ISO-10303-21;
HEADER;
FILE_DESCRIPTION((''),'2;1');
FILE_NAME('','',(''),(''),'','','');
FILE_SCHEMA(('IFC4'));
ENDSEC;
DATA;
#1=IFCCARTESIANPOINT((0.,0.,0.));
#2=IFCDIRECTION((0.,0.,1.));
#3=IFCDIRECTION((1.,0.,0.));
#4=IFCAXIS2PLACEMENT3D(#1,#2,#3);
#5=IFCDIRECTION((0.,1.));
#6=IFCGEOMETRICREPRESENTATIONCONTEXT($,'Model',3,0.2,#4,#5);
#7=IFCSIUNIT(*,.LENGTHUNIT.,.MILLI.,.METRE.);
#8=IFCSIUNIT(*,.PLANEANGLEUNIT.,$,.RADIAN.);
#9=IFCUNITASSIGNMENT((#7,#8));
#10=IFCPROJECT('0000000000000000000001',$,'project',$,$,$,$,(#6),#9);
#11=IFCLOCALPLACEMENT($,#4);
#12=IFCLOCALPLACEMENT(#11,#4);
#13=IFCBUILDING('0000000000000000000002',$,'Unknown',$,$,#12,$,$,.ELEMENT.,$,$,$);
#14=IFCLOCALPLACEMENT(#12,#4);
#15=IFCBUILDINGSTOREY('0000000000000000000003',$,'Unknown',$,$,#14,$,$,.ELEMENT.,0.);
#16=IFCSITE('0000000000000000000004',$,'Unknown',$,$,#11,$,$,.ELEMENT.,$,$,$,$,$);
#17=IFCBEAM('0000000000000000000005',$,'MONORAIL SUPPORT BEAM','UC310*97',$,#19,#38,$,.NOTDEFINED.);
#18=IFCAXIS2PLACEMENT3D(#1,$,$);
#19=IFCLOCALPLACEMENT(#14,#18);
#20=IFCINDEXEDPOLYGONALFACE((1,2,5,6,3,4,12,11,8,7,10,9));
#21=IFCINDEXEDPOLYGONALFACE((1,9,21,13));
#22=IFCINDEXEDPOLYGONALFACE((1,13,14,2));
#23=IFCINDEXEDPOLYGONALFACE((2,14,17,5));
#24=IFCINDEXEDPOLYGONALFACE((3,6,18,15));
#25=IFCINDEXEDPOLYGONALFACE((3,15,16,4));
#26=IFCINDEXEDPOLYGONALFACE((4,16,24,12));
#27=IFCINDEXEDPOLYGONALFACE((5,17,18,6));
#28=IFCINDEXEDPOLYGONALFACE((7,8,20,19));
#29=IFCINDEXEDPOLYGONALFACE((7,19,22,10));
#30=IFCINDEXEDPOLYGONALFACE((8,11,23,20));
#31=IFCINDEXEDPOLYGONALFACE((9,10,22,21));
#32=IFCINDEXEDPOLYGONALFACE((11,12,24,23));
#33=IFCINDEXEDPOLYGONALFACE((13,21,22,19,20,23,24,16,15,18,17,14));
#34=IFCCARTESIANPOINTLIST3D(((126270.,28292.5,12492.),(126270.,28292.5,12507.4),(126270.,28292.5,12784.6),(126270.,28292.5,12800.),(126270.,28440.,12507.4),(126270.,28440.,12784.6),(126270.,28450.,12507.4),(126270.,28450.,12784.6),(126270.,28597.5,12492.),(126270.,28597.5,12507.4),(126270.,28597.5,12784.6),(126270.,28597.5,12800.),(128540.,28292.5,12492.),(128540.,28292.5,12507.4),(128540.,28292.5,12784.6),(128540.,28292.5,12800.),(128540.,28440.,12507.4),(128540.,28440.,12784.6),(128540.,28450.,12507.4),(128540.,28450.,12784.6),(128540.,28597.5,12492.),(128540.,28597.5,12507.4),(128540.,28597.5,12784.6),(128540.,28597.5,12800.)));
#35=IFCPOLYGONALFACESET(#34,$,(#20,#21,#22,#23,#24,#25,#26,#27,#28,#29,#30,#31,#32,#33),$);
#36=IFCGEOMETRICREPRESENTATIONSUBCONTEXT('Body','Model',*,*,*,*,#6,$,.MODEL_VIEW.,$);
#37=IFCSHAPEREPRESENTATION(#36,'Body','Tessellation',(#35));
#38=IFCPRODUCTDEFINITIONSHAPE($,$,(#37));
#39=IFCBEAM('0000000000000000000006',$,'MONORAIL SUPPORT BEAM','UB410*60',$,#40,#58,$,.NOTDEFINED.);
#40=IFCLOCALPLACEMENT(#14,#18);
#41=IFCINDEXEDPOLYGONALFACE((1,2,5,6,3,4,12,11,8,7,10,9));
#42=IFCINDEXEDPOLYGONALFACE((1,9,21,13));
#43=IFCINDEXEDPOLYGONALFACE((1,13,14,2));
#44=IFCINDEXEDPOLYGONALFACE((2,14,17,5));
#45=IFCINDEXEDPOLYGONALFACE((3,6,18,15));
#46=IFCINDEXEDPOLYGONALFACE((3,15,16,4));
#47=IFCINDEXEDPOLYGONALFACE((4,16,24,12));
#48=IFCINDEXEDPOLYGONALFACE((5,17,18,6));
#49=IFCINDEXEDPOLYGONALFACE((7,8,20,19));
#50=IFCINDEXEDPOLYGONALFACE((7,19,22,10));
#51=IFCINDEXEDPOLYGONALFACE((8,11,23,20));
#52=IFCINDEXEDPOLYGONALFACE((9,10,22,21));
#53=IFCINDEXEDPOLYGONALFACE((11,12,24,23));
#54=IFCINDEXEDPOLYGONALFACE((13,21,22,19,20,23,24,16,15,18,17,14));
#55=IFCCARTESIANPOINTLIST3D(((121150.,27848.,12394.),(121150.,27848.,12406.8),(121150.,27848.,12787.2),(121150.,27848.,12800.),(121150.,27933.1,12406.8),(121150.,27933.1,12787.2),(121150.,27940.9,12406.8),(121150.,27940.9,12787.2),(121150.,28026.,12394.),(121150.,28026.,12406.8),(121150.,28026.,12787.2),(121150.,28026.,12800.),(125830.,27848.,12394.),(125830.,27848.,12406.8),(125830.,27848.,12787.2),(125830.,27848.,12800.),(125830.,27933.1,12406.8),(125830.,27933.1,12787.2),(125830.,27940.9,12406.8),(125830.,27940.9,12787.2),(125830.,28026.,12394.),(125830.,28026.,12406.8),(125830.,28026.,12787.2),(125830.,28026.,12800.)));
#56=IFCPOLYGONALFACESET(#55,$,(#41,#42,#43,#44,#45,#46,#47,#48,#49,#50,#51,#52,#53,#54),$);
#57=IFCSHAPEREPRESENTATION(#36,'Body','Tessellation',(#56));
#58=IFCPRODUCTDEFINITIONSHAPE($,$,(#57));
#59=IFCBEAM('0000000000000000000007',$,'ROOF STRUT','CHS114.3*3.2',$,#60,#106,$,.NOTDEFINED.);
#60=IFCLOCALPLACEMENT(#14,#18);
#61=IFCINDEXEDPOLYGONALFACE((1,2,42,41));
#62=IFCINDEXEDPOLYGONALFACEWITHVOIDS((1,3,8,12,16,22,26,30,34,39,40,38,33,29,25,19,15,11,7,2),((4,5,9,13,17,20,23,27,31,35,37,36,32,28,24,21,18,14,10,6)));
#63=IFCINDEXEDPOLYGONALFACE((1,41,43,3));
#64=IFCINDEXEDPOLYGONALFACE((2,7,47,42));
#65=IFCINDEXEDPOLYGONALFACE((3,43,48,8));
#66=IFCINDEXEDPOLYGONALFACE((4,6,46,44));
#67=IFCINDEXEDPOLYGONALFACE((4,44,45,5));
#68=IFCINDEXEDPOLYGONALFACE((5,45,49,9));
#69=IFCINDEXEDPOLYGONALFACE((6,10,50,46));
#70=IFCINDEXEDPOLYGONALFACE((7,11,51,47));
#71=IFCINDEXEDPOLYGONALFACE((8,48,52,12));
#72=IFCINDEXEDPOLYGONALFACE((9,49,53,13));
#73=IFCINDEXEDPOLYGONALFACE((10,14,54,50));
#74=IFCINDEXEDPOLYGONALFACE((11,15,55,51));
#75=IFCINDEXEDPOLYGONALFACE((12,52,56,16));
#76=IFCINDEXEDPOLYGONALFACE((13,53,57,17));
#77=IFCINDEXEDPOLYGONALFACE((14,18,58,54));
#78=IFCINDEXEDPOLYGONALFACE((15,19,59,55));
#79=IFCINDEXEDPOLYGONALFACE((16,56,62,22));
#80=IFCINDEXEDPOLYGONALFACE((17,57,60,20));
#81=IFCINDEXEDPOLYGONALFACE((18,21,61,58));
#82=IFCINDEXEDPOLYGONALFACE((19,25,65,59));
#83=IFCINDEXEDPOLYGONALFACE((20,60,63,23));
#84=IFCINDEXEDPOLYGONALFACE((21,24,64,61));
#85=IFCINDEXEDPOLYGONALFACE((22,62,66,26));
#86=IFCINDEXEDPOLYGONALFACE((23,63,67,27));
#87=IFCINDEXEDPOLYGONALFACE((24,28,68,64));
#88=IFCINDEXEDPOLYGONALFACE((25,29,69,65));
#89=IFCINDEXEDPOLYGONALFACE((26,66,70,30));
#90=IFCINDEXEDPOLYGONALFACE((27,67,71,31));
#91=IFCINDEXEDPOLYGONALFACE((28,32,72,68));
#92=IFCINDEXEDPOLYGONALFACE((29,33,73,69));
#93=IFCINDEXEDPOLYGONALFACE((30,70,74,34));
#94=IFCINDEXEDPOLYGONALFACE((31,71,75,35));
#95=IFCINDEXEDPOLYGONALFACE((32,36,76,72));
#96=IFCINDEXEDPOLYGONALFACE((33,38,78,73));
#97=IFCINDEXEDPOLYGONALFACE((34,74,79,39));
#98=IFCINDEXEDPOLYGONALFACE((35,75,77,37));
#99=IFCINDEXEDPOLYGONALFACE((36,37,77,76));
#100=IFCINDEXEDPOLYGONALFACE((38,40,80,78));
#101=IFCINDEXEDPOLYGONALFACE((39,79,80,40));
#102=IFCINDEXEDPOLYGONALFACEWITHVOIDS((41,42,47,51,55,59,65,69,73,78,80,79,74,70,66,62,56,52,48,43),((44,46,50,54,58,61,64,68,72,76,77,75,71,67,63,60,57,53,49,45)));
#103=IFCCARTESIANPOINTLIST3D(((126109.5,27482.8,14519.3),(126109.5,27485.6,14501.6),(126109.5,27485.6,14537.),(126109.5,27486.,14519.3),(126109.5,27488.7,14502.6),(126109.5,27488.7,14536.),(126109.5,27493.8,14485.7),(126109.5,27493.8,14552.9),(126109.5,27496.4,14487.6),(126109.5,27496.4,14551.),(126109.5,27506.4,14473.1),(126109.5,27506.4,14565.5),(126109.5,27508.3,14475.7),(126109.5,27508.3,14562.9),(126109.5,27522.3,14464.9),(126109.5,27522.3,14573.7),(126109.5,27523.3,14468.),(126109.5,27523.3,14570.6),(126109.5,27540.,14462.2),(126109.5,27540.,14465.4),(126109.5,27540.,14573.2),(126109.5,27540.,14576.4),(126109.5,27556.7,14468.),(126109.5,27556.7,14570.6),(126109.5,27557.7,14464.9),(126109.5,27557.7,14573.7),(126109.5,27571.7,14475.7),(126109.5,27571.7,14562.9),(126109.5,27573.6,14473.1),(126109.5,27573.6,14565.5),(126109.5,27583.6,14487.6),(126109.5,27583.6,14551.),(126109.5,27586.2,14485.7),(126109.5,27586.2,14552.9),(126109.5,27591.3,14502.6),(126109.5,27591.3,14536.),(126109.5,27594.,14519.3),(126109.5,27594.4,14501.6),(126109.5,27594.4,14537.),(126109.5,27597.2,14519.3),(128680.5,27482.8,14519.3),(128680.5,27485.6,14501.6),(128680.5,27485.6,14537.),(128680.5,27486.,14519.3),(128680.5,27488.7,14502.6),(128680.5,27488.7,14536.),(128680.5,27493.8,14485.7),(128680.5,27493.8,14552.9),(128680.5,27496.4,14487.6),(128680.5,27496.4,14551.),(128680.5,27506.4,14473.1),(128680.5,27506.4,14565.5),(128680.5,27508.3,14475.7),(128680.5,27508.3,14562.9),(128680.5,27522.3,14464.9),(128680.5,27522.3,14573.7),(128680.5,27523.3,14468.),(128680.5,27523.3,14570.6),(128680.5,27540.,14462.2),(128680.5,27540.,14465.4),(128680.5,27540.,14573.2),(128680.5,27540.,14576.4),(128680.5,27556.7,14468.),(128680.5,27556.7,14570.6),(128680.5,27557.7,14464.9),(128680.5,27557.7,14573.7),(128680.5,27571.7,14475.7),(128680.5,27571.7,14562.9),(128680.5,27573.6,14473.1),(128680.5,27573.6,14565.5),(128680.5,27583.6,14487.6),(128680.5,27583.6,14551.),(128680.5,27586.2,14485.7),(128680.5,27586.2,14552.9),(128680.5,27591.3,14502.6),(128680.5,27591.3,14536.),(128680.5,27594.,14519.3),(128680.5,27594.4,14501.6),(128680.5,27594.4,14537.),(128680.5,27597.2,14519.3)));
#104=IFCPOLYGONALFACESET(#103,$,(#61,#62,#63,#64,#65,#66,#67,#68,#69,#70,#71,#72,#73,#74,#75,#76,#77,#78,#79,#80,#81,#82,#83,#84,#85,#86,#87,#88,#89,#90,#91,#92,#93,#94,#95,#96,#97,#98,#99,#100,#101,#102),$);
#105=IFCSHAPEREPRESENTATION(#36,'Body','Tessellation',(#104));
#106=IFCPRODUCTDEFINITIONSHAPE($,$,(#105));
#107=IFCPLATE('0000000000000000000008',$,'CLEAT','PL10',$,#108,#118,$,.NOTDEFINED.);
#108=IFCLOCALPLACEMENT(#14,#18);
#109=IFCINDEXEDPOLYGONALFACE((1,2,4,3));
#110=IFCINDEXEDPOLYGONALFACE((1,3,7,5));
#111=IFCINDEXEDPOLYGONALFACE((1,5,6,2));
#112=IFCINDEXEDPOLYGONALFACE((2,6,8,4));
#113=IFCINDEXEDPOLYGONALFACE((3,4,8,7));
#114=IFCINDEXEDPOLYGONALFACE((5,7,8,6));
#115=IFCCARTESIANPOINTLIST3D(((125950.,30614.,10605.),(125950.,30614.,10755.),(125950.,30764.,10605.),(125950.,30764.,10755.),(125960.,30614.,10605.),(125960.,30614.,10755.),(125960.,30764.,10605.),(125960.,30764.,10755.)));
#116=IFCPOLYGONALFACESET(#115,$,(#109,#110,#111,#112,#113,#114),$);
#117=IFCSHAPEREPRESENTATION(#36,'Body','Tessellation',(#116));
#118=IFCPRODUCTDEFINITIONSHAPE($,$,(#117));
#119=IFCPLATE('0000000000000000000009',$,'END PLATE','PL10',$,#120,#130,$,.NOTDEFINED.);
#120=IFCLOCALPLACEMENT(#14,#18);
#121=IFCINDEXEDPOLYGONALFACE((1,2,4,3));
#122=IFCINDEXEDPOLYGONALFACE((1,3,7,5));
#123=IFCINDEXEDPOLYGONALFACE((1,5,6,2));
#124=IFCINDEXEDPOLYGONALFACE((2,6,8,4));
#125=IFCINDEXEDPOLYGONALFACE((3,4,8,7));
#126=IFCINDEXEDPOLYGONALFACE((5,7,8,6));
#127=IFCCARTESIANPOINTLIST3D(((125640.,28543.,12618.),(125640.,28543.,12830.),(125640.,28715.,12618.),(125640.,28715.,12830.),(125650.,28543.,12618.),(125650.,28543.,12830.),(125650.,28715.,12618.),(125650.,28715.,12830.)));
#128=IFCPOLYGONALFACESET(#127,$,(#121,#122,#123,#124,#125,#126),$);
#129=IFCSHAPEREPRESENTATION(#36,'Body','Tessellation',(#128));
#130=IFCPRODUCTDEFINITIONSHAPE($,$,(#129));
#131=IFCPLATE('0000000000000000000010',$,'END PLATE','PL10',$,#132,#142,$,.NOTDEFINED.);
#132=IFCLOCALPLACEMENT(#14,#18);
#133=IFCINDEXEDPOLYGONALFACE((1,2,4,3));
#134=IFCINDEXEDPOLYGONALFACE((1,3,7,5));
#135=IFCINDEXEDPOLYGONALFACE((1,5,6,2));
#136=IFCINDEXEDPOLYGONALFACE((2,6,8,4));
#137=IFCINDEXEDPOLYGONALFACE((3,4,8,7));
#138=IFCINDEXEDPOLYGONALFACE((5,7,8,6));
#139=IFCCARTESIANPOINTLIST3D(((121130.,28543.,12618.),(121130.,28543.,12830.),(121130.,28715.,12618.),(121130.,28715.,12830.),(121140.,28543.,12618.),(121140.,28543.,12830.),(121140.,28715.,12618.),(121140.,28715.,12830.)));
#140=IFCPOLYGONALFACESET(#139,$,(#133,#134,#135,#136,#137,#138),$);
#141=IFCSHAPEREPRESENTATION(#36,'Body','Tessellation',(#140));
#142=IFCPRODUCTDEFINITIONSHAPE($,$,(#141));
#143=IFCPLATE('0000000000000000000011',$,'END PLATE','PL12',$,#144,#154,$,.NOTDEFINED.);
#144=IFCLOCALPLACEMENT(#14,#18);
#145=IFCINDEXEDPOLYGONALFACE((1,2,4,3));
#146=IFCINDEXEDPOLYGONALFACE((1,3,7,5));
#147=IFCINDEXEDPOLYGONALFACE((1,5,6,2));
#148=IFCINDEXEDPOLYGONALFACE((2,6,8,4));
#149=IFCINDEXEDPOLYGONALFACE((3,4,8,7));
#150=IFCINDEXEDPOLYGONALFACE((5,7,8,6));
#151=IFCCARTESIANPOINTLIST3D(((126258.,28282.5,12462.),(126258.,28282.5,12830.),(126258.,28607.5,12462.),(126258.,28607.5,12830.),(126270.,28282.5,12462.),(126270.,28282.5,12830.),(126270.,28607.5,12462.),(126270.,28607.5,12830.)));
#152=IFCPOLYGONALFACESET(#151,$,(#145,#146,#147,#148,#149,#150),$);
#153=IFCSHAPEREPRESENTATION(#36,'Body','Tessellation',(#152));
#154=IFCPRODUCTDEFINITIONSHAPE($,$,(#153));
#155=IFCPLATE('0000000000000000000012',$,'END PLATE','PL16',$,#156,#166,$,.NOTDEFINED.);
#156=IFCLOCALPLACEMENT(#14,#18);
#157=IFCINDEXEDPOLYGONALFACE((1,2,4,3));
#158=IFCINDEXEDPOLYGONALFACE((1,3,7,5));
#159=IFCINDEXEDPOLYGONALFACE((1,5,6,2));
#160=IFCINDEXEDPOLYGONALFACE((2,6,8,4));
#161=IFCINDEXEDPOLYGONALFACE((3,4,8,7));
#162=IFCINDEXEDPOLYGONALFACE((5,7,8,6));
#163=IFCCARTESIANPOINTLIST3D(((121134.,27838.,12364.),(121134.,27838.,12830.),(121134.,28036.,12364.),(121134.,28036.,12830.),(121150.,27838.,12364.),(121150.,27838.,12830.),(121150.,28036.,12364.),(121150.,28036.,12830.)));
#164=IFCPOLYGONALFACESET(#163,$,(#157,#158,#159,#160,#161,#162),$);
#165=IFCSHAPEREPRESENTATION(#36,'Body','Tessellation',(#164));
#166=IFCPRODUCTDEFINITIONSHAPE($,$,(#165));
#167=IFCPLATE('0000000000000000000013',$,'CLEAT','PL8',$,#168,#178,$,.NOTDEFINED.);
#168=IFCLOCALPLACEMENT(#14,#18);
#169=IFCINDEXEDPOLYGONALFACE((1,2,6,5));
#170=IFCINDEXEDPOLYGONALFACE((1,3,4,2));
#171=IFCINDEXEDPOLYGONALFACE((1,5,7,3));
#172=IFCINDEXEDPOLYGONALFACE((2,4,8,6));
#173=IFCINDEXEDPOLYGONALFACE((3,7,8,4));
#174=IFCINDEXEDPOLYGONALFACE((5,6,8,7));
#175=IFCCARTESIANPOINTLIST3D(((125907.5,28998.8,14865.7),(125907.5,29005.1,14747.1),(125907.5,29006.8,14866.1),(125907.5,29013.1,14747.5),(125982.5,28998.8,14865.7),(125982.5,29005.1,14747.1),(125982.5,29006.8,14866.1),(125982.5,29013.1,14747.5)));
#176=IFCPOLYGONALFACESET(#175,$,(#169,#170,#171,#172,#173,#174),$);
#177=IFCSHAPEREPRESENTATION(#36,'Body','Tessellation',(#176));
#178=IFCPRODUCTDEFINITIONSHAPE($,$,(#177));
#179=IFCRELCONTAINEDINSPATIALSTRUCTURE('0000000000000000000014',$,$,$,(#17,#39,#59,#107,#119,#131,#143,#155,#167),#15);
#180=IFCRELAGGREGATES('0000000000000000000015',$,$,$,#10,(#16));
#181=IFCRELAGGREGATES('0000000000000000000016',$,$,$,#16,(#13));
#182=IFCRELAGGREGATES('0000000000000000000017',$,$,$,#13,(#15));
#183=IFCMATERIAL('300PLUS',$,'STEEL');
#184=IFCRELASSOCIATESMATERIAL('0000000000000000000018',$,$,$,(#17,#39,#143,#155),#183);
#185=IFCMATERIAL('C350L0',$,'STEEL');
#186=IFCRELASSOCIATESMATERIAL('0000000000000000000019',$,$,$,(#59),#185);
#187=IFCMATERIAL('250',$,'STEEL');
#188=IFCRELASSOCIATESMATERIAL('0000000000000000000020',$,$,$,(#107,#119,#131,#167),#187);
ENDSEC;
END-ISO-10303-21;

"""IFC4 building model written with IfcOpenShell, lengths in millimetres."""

from ifc_helpers import new_model, si_unit, direction, frame, origin_with_axes, place, context, subcontext, project, spatial, line, indexed_curve, outline, extrude, material, element, save


model = new_model("IFC4")

# Units and contexts
model_context = context("Model", 3, precision=0.2, world=origin_with_axes(), true_north=direction((0.0, 1.0)))
body_context = subcontext(model_context, "Body", "Model", "MODEL_VIEW")
ifc_project = project(units=[si_unit("LENGTHUNIT", "METRE", prefix="MILLI"), si_unit("PLANEANGLEUNIT", "RADIAN")], contexts=[model_context])

# Site, building, storey
site_placement = place(None, origin_with_axes())
site = spatial("IfcSite", under=ifc_project, at=site_placement, Name="Unknown", CompositionType="ELEMENT")
building_placement = place(site_placement, origin_with_axes())
building = spatial("IfcBuilding", under=site, at=building_placement, Name="Unknown", CompositionType="ELEMENT")
storey_placement = place(building_placement, origin_with_axes())
storey = spatial("IfcBuildingStorey", under=building, at=storey_placement, Name="Unknown", CompositionType="ELEMENT", Elevation=0.0)

# Shared definitions
ifc_material_1 = material(Name="C350L0", Category="STEEL")

# Beams
ifc_material_2 = material(Name="300PLUS", Category="STEEL")
beam_1_placement = place(storey_placement, frame((126270.0, 28445.0, 12646.0), z_axis=(0.0, -1.0, 0.0), x_axis=(1.0, 0.0, 0.0)))
element("IfcBeam", 1, at=beam_1_placement, inside=storey, material=ifc_material_2, Name="MONORAIL SUPPORT BEAM", Description="UC310*97", PredefinedType="NOTDEFINED", context=body_context, shape_type="SolidModel", body=[
    extrude(outline(indexed_curve([(-152.5, -154.0), (152.5, -154.0), (152.5, -138.6), (5.0, -138.6), (5.0, 138.6), (152.5, 138.6), (152.5, 154.0), (-152.5, 154.0), (-152.5, 138.6), (-5.0, 138.6), (-5.0, -138.6), (-152.5, -138.6)], segments=[line(1, 2, 3, 4, 5, 6, 7, 8, 9, 10, 11, 12, 1)])), frame((0.0, 0.0, 0.0), z_axis=(-1.0, 0.0, 0.0), x_axis=(0.0, 0.0, 1.0)), (0.0, 0.0, -1.0), 2270.0),
])
beam_2_placement = place(storey_placement, frame((121150.0, 27937.0, 12597.0), z_axis=(0.0, -1.0, 0.0), x_axis=(1.0, 0.0, 0.0)))
element("IfcBeam", 2, at=beam_2_placement, inside=storey, material=ifc_material_2, Name="MONORAIL SUPPORT BEAM", Description="UB410*60", PredefinedType="NOTDEFINED", context=body_context, shape_type="SolidModel", body=[
    extrude(outline(indexed_curve([(-89.0, -203.0), (89.0, -203.0), (89.0, -190.2), (3.9, -190.2), (3.9, 190.2), (89.0, 190.2), (89.0, 203.0), (-89.0, 203.0), (-89.0, 190.2), (-3.9, 190.2), (-3.9, -190.2), (-89.0, -190.2)], segments=[line(1, 2, 3, 4, 5, 6, 7, 8, 9, 10, 11, 12, 1)])), frame((0.0, 0.0, 0.0), z_axis=(-1.0, 0.0, 0.0), x_axis=(0.0, 0.0, 1.0)), (0.0, 0.0, -1.0), 4680.0),
])
beam_3_placement = place(storey_placement, frame((126109.5, 27540.0, 14519.3), z_axis=(0.0, 0.0, 1.0), x_axis=(1.0, 0.0, 0.0)))
element("IfcBeam", 3, at=beam_3_placement, inside=storey, material=ifc_material_1, Name="ROOF STRUT", Description="CHS114.3*3.2", PredefinedType="NOTDEFINED", context=body_context, shape_type="SolidModel", body=[
    extrude(outline(indexed_curve([(57.1, 0.0), (54.4, 17.7), (46.2, 33.6), (33.6, 46.2), (17.7, 54.4), (0.0, 57.1), (-17.7, 54.4), (-33.6, 46.2), (-46.2, 33.6), (-54.4, 17.7), (-57.1, 0.0), (-54.4, -17.7), (-46.2, -33.6), (-33.6, -46.2), (-17.7, -54.4), (0.0, -57.1), (17.7, -54.4), (33.6, -46.2), (46.2, -33.6), (54.4, -17.7)], segments=[line(1, 2, 3, 4, 5, 6, 7, 8, 9, 10, 11, 12, 13, 14, 15, 16, 17, 18, 19, 20, 1)]), holes=[indexed_curve([(54.0, 0.0), (51.3, -16.7), (43.6, -31.7), (31.7, -43.6), (16.7, -51.3), (0.0, -54.0), (-16.7, -51.3), (-31.7, -43.6), (-43.6, -31.7), (-51.3, -16.7), (-54.0, 0.0), (-51.3, 16.7), (-43.6, 31.7), (-31.7, 43.6), (-16.7, 51.3), (0.0, 54.0), (16.7, 51.3), (31.7, 43.6), (43.6, 31.7), (51.3, 16.7)], segments=[line(1, 2, 3, 4, 5, 6, 7, 8, 9, 10, 11, 12, 13, 14, 15, 16, 17, 18, 19, 20, 1)])]), frame((0.0, 0.0, 0.0), z_axis=(-1.0, 0.0, 0.0), x_axis=(0.0, 0.0, 1.0)), (0.0, 0.0, -1.0), 2571.0),
])

# Plates
ifc_material_3 = material(Name="250", Category="STEEL")
plate_1_placement = place(storey_placement, frame((125955.0, 30614.0, 10605.0), z_axis=(1.0, 0.0, 0.0), x_axis=(0.0, 1.0, 0.0)))
element("IfcPlate", 4, at=plate_1_placement, inside=storey, material=ifc_material_3, Name="CLEAT", Description="PL10", PredefinedType="NOTDEFINED", context=body_context, shape_type="SolidModel", body=[
    extrude(outline(indexed_curve([(0.0, 0.0), (150.0, 0.0), (150.0, 150.0), (0.0, 150.0)], segments=[line(1, 2, 3, 4, 1)])), frame((0.0, 0.0, 5.0), z_axis=(0.0, 0.0, 1.0), x_axis=(1.0, 0.0, 0.0)), (0.0, 0.0, -1.0), 10.0),
])
for number, where, z_axis, x_axis, name in (
    (5, (125645.0, 28715.0, 12618.0), (-1.0, 0.0, 0.0), (0.0, -1.0, 0.0), "END PLATE"),
    (6, (121135.0, 28715.0, 12618.0), (-1.0, 0.0, 0.0), (0.0, -1.0, 0.0), "END PLATE"),
):
    element("IfcPlate", number, at=place(storey_placement, frame(where, z_axis=z_axis, x_axis=x_axis)), inside=storey, material=ifc_material_3, Name=name, Description="PL10", PredefinedType="NOTDEFINED", context=body_context, shape_type="SolidModel", body=[
        extrude(outline(indexed_curve([(0.0, 0.0), (172.0, 0.0), (172.0, 212.0), (0.0, 212.0)], segments=[line(1, 2, 3, 4, 1)])), frame((0.0, 0.0, 5.0), z_axis=(0.0, 0.0, 1.0), x_axis=(1.0, 0.0, 0.0)), (0.0, 0.0, -1.0), 10.0),
    ])
plate_2_placement = place(storey_placement, frame((126264.0, 28607.5, 12462.0), z_axis=(-1.0, 0.0, 0.0), x_axis=(0.0, -1.0, 0.0)))
element("IfcPlate", 7, at=plate_2_placement, inside=storey, material=ifc_material_2, Name="END PLATE", Description="PL12", PredefinedType="NOTDEFINED", context=body_context, shape_type="SolidModel", body=[
    extrude(outline(indexed_curve([(0.0, 0.0), (325.0, 0.0), (325.0, 368.0), (0.0, 368.0)], segments=[line(1, 2, 3, 4, 1)])), frame((0.0, 0.0, 6.0), z_axis=(0.0, 0.0, 1.0), x_axis=(1.0, 0.0, 0.0)), (0.0, 0.0, -1.0), 12.0),
])
plate_3_placement = place(storey_placement, frame((121142.0, 28036.0, 12364.0), z_axis=(-1.0, 0.0, 0.0), x_axis=(0.0, -1.0, 0.0)))
element("IfcPlate", 8, at=plate_3_placement, inside=storey, material=ifc_material_2, Name="END PLATE", Description="PL16", PredefinedType="NOTDEFINED", context=body_context, shape_type="SolidModel", body=[
    extrude(outline(indexed_curve([(0.0, 0.0), (198.0, 0.0), (198.0, 466.0), (0.0, 466.0)], segments=[line(1, 2, 3, 4, 1)])), frame((0.0, 0.0, 8.0), z_axis=(0.0, 0.0, 1.0), x_axis=(1.0, 0.0, 0.0)), (0.0, 0.0, -1.0), 16.0),
])
plate_4_placement = place(storey_placement, frame((125907.5, 29002.8, 14865.9), z_axis=(0.0, 0.998592, 0.053045), x_axis=(1.0, 0.0, 0.0)))
element("IfcPlate", 9, at=plate_4_placement, inside=storey, material=ifc_material_3, Name="CLEAT", Description="PL8", PredefinedType="NOTDEFINED", context=body_context, shape_type="SolidModel", body=[
    extrude(outline(indexed_curve([(0.0, 0.0), (75.0, 0.0), (75.0, 118.8), (0.0, 118.8)], segments=[line(1, 2, 3, 4, 1)])), frame((0.0, 0.0, 4.0), z_axis=(0.0, 0.0, 1.0), x_axis=(1.0, 0.0, 0.0)), (0.0, 0.0, -1.0), 8.0),
])

save(model, "model.ifc")
